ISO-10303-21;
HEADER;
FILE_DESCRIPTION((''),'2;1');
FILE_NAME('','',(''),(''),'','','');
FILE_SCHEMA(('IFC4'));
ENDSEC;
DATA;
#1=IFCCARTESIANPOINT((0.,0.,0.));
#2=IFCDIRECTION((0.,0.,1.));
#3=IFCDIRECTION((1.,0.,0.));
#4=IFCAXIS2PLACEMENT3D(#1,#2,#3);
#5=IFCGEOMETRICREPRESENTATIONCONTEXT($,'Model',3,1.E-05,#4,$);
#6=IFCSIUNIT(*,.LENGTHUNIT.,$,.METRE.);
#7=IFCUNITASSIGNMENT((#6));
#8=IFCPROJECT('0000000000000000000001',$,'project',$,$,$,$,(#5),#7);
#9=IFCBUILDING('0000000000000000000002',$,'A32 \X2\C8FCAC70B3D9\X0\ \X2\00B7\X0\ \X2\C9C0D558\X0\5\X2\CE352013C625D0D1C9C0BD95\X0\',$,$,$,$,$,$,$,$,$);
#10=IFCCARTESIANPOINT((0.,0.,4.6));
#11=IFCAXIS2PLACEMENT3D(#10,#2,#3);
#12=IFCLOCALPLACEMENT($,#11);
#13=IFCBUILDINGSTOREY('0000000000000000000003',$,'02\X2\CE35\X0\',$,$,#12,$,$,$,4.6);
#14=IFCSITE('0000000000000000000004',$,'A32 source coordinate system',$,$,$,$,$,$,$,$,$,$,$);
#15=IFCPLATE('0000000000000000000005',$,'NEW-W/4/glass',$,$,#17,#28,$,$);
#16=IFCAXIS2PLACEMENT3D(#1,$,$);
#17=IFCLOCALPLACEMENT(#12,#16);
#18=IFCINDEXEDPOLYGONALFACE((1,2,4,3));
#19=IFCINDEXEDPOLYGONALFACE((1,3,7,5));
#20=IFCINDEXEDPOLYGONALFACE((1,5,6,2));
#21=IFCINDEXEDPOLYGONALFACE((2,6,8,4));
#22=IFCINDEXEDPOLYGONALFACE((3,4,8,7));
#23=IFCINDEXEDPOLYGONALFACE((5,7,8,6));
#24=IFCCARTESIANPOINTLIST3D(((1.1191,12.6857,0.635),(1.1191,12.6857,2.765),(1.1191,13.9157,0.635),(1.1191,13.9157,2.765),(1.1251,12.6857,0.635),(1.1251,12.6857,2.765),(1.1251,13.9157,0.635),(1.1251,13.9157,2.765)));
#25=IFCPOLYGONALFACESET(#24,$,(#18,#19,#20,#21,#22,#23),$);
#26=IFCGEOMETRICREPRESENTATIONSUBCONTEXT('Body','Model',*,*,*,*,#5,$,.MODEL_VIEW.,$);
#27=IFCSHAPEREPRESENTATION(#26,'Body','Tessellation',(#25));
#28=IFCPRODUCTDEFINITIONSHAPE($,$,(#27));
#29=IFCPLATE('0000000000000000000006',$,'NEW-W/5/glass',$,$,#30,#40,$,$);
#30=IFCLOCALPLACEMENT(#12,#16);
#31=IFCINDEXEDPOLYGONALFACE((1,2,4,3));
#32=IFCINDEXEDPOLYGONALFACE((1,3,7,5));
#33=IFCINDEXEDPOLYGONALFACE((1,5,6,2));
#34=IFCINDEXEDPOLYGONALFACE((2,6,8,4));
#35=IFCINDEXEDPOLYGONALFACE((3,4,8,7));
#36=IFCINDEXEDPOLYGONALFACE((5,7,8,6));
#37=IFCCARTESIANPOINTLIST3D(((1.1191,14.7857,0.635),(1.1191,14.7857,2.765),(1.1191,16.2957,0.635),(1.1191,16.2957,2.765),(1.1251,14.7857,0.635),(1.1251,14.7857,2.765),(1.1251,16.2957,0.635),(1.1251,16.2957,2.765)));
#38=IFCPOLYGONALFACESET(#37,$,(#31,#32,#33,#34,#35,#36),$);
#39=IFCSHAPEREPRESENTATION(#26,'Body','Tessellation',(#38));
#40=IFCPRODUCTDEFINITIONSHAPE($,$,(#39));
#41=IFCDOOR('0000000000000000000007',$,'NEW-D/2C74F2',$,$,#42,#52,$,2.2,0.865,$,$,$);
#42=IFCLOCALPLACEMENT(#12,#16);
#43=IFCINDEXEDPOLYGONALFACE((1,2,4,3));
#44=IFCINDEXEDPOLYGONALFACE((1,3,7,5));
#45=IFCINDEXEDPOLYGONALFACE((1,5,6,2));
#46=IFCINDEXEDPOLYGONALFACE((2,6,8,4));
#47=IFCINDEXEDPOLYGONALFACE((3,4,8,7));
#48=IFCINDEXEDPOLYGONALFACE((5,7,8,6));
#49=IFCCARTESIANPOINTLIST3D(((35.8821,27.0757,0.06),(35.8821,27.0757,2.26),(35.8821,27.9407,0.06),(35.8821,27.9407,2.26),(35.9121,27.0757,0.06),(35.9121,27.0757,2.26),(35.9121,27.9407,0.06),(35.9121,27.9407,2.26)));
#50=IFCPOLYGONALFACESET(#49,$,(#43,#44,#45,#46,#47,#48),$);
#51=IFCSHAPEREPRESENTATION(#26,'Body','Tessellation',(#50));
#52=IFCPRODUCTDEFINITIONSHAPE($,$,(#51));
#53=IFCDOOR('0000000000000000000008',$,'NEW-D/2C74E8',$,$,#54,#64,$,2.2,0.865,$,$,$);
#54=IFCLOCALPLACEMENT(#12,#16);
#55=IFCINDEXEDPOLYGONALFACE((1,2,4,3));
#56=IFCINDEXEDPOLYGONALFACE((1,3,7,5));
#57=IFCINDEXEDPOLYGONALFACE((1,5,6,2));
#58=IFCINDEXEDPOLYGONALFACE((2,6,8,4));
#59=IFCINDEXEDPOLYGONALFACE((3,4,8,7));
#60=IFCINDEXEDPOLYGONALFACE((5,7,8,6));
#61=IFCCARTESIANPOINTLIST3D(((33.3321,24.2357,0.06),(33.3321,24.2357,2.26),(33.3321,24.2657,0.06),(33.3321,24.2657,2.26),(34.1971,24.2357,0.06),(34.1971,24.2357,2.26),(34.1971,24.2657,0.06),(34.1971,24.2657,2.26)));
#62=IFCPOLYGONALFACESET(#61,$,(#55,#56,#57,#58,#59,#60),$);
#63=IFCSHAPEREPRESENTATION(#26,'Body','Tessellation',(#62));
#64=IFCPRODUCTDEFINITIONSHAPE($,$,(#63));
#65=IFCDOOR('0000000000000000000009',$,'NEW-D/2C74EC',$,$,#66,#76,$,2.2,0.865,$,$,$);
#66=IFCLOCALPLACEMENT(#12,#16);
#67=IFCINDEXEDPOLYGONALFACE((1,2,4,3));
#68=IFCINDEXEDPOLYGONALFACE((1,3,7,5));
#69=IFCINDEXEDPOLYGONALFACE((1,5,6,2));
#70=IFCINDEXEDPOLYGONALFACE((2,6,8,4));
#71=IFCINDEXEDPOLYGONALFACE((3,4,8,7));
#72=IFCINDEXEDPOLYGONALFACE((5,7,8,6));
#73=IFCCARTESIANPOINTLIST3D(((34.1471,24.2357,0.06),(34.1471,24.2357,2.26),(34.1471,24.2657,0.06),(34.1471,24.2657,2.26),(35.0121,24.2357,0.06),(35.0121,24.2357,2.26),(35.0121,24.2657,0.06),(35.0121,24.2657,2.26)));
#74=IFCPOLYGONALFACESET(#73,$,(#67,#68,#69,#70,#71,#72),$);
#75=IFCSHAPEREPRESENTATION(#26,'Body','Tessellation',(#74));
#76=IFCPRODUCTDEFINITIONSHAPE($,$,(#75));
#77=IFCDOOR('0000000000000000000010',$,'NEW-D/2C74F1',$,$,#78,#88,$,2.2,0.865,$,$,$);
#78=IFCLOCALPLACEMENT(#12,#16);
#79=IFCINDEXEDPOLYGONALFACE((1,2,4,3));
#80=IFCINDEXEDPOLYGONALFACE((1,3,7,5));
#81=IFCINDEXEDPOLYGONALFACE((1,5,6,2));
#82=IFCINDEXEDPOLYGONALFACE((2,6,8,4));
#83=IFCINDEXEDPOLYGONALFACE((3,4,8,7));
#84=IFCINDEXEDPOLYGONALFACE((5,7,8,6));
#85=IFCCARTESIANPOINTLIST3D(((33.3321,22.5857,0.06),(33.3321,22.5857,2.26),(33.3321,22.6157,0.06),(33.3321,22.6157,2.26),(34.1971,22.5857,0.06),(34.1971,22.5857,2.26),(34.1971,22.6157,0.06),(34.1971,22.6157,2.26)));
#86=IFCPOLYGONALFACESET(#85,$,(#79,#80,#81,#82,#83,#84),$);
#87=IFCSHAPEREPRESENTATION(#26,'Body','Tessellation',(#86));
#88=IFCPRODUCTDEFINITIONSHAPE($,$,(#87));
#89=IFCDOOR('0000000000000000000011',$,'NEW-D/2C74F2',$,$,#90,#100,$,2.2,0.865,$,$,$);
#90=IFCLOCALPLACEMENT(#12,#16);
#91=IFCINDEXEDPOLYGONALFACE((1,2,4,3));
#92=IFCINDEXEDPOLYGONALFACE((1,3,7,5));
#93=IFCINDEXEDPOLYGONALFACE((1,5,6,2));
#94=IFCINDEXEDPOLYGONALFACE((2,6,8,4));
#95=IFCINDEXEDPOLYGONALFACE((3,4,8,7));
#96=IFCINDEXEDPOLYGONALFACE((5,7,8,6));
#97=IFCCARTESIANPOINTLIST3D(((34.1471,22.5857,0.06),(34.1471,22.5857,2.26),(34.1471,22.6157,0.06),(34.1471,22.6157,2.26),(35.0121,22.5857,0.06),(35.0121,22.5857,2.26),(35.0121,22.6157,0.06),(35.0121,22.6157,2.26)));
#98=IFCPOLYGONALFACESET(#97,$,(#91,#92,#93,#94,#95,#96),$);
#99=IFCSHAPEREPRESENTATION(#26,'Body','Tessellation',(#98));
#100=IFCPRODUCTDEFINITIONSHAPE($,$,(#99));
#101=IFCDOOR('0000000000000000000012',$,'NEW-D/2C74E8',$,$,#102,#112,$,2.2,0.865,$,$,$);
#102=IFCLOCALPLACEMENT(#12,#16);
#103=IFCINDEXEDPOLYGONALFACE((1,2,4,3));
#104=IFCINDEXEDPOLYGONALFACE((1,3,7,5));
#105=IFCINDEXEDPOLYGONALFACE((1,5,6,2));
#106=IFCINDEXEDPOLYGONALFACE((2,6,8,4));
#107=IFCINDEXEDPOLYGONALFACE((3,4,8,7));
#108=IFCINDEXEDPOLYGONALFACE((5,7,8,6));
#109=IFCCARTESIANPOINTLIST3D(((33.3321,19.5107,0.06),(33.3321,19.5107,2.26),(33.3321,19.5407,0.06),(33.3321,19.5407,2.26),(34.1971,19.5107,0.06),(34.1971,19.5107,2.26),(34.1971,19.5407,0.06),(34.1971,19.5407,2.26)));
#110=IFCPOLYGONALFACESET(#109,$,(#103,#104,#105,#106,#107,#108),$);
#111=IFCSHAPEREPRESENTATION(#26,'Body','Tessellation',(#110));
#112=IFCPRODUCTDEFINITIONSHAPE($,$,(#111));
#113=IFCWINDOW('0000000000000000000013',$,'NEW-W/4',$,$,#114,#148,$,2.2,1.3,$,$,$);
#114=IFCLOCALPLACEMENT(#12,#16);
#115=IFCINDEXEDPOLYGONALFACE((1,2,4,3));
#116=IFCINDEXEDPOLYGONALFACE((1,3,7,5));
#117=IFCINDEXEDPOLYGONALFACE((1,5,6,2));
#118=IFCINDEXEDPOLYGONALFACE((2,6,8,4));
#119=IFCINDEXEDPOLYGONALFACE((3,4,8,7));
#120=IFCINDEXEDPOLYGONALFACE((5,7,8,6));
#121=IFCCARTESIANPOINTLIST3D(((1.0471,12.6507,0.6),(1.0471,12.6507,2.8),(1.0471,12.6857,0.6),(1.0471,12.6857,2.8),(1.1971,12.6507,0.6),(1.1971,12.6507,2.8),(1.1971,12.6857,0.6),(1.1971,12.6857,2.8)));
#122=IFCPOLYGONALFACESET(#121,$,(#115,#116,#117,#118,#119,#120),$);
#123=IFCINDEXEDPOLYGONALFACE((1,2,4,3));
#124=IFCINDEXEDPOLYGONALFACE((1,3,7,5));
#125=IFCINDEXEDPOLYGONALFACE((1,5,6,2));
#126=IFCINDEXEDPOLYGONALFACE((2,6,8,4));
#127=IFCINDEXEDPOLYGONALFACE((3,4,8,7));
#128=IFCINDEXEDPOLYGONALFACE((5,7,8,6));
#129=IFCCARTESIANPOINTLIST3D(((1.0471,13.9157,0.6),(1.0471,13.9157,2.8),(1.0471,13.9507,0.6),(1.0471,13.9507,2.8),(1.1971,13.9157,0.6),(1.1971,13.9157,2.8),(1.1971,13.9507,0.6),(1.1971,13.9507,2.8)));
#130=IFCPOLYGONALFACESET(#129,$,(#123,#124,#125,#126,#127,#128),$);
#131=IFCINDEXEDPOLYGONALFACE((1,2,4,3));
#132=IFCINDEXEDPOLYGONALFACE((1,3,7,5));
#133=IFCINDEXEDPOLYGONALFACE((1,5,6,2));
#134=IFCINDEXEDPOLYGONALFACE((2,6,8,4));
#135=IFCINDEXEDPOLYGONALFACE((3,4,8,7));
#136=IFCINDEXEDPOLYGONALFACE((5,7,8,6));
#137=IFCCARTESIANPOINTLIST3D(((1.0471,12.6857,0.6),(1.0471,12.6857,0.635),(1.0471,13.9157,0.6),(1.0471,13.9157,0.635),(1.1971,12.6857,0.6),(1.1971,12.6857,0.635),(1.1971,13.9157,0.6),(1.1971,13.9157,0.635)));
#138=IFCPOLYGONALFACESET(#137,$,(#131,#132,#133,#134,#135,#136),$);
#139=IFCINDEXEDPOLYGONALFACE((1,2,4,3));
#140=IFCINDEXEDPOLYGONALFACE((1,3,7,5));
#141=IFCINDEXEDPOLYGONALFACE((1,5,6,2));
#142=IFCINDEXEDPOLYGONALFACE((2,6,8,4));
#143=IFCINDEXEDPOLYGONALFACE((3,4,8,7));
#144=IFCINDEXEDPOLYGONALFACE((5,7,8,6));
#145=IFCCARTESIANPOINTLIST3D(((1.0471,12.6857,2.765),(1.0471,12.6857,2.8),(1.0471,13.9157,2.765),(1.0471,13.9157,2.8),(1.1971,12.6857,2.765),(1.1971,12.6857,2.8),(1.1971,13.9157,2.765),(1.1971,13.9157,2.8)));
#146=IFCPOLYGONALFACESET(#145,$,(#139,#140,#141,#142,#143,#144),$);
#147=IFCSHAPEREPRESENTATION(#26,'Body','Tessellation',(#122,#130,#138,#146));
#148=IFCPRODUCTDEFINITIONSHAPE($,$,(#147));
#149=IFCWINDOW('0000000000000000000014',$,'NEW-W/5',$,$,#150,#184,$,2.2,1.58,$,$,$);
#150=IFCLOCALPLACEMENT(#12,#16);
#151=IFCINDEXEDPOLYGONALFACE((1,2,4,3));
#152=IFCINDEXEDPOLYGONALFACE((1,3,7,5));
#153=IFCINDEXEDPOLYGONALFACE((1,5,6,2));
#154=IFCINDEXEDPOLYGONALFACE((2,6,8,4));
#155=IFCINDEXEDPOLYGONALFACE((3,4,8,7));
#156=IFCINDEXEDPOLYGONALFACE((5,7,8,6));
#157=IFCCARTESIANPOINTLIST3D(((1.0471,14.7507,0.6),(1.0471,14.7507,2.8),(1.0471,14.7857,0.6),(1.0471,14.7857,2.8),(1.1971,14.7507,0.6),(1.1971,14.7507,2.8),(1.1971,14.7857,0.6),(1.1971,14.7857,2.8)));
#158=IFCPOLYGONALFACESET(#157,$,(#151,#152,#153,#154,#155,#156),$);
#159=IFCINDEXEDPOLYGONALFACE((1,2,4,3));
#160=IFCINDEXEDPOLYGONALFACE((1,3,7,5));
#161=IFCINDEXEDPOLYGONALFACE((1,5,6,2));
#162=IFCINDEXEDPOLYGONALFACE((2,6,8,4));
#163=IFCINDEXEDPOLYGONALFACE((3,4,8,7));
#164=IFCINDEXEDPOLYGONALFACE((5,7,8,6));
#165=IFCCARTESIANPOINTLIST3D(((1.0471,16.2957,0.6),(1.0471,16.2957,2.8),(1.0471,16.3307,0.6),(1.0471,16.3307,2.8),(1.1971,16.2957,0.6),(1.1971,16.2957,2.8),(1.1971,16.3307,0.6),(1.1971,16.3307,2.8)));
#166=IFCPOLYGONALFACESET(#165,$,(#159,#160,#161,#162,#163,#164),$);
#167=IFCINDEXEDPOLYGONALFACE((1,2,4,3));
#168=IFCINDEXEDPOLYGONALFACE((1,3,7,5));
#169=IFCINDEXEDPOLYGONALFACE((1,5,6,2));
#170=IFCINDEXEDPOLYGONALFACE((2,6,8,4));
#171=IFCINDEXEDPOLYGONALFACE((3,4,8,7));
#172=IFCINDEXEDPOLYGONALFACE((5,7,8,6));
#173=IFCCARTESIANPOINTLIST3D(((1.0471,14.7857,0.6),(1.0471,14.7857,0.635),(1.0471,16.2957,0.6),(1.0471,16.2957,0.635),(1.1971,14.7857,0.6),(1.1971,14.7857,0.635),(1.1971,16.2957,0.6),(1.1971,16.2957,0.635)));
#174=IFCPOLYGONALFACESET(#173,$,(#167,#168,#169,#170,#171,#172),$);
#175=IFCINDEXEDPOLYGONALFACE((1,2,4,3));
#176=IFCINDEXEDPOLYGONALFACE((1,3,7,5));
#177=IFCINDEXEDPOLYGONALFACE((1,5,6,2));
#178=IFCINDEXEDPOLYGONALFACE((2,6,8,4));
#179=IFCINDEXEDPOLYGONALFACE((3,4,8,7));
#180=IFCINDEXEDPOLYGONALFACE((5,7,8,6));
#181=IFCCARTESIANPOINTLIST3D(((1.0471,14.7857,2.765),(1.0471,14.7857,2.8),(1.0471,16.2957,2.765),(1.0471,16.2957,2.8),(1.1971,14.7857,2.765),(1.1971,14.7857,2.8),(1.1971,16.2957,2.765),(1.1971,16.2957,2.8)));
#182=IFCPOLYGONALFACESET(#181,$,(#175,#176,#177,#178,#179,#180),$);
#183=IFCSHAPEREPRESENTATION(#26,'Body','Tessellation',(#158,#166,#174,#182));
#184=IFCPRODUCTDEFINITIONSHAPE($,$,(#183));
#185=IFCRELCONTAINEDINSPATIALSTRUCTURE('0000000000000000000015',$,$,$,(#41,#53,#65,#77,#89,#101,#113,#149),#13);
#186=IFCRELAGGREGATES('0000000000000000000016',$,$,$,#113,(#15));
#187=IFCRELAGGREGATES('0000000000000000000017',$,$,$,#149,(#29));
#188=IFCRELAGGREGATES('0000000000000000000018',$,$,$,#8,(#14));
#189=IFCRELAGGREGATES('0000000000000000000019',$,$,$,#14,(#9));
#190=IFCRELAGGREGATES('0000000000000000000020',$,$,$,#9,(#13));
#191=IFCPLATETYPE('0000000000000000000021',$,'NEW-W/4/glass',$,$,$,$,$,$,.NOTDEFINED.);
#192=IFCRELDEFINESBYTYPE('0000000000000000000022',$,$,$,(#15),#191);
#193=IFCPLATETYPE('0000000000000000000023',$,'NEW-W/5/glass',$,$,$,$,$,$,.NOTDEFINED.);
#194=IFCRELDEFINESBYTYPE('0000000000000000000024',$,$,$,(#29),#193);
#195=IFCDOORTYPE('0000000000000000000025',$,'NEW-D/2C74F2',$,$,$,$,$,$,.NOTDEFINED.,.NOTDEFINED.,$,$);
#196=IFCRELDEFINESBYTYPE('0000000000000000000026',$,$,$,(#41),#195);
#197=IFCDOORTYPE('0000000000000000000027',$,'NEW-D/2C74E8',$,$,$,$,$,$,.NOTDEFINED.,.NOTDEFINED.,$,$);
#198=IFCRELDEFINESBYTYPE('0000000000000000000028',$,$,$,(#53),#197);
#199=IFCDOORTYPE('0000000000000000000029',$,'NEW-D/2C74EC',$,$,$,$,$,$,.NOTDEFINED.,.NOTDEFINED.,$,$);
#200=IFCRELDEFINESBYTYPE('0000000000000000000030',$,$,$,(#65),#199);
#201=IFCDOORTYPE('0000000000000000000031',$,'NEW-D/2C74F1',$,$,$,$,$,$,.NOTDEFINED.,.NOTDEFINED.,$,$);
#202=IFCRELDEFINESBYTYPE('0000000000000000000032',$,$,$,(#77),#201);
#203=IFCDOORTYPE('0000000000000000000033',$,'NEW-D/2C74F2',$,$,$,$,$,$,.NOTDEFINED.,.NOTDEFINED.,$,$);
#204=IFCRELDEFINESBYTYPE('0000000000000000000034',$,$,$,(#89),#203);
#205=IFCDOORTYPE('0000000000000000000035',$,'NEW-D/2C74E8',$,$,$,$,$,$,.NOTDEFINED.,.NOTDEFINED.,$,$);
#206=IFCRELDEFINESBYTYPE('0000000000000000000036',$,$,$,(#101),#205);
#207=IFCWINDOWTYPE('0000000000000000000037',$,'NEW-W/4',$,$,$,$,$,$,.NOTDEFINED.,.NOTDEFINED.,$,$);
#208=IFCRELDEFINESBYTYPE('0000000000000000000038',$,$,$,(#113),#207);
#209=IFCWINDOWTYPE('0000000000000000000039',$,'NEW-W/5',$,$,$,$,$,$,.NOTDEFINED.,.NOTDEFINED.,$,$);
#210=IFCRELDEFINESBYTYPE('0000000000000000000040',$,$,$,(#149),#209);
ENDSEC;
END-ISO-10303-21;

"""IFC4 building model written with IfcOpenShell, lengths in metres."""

from ifc_helpers import new_model, si_unit, frame, origin, origin_with_axes, place, context, subcontext, project, spatial, polyline, outline, extrude, source, transform, mapped, type_object, type_shapes, element, aggregate, save


model = new_model("IFC4")

# Units and contexts
model_context = context("Model", 3, precision=1e-05, world=origin_with_axes())
body_context = subcontext(model_context, "Body", "Model", "MODEL_VIEW")
ifc_project = project(units=[si_unit("LENGTHUNIT", "METRE")], contexts=[model_context])

# Plates
storey_placement = place(None, frame((0.0, 0.0, 4.6), z_axis=(0.0, 0.0, 1.0), x_axis=(1.0, 0.0, 0.0)))
plate_type_1 = type_object("IfcPlateType", Name="NEW-W/4/glass", PredefinedType="NOTDEFINED")
shared_shape_1 = source(origin(), body_context, "Body", "SweptSolid", [
    extrude(outline(polyline([(1.1251, 12.6857), (1.1191, 12.6857), (1.1191, 13.9157), (1.1251, 13.9157), (1.1251, 12.6857)])), frame((0.0, 0.0, 0.635)), (0.0, 0.0, 1.0), 2.13),
])
type_shapes(plate_type_1, [shared_shape_1])
window_1_placement = place(storey_placement, origin_with_axes())
plate_1_placement = place(window_1_placement, origin_with_axes())
plate_1 = element("IfcPlate", 1, at=plate_1_placement, type_object=plate_type_1, Name="NEW-W/4/glass", context=body_context, shape_type="MappedRepresentation", body=[
    mapped(shared_shape_1, transform((0.0, 0.0, 0.0), scale=1.0)),
])
plate_type_2 = type_object("IfcPlateType", Name="NEW-W/5/glass", PredefinedType="NOTDEFINED")
shared_shape_2 = source(origin(), body_context, "Body", "SweptSolid", [
    extrude(outline(polyline([(1.1251, 14.7857), (1.1191, 14.7857), (1.1191, 16.2957), (1.1251, 16.2957), (1.1251, 14.7857)])), frame((0.0, 0.0, 0.635)), (0.0, 0.0, 1.0), 2.13),
])
type_shapes(plate_type_2, [shared_shape_2])
window_2_placement = place(storey_placement, origin_with_axes())
plate_2_placement = place(window_2_placement, origin_with_axes())
plate_2 = element("IfcPlate", 2, at=plate_2_placement, type_object=plate_type_2, Name="NEW-W/5/glass", context=body_context, shape_type="MappedRepresentation", body=[
    mapped(shared_shape_2, transform((0.0, 0.0, 0.0), scale=1.0)),
])

# Site, building, storey
site = spatial("IfcSite", under=ifc_project, Name="A32 source coordinate system")
building = spatial("IfcBuilding", under=site, Name="A32 주거동 · 지하5층–옥탑지붕")
storey = spatial("IfcBuildingStorey", under=building, at=storey_placement, Name="02층", Elevation=4.6)

# Doors
door_type_1 = type_object("IfcDoorType", Name="NEW-D/2C74F2", OperationType="NOTDEFINED", PredefinedType="NOTDEFINED")
shared_shape_3 = source(origin(), body_context, "Body", "SweptSolid", [
    extrude(outline(polyline([(35.8821, 27.0757), (35.8821, 27.9407), (35.9121, 27.9407), (35.9121, 27.0757), (35.8821, 27.0757)])), frame((0.0, 0.0, 0.06)), (0.0, 0.0, 1.0), 2.2),
])
type_shapes(door_type_1, [shared_shape_3])
door_1_placement = place(storey_placement, origin_with_axes())
element("IfcDoor", 3, at=door_1_placement, inside=storey, type_object=door_type_1, Name="NEW-D/2C74F2", OverallHeight=2.2, OverallWidth=0.865, context=body_context, shape_type="MappedRepresentation", body=[
    mapped(shared_shape_3, transform((0.0, 0.0, 0.0), scale=1.0)),
])
door_type_2 = type_object("IfcDoorType", Name="NEW-D/2C74E8", OperationType="NOTDEFINED", PredefinedType="NOTDEFINED")
shared_shape_4 = source(origin(), body_context, "Body", "SweptSolid", [
    extrude(outline(polyline([(34.1971, 24.2357), (33.3321, 24.2357), (33.3321, 24.2657), (34.1971, 24.2657), (34.1971, 24.2357)])), frame((0.0, 0.0, 0.06)), (0.0, 0.0, 1.0), 2.2),
])
type_shapes(door_type_2, [shared_shape_4])
door_2_placement = place(storey_placement, origin_with_axes())
element("IfcDoor", 4, at=door_2_placement, inside=storey, type_object=door_type_2, Name="NEW-D/2C74E8", OverallHeight=2.2, OverallWidth=0.865, context=body_context, shape_type="MappedRepresentation", body=[
    mapped(shared_shape_4, transform((0.0, 0.0, 0.0), scale=1.0)),
])
door_type_3 = type_object("IfcDoorType", Name="NEW-D/2C74EC", OperationType="NOTDEFINED", PredefinedType="NOTDEFINED")
shared_shape_5 = source(origin(), body_context, "Body", "SweptSolid", [
    extrude(outline(polyline([(35.0121, 24.2657), (35.0121, 24.2357), (34.1471, 24.2357), (34.1471, 24.2657), (35.0121, 24.2657)])), frame((0.0, 0.0, 0.06)), (0.0, 0.0, 1.0), 2.2),
])
type_shapes(door_type_3, [shared_shape_5])
door_3_placement = place(storey_placement, origin_with_axes())
element("IfcDoor", 5, at=door_3_placement, inside=storey, type_object=door_type_3, Name="NEW-D/2C74EC", OverallHeight=2.2, OverallWidth=0.865, context=body_context, shape_type="MappedRepresentation", body=[
    mapped(shared_shape_5, transform((0.0, 0.0, 0.0), scale=1.0)),
])
door_type_4 = type_object("IfcDoorType", Name="NEW-D/2C74F1", OperationType="NOTDEFINED", PredefinedType="NOTDEFINED")
shared_shape_6 = source(origin(), body_context, "Body", "SweptSolid", [
    extrude(outline(polyline([(33.3321, 22.5857), (33.3321, 22.6157), (34.1971, 22.6157), (34.1971, 22.5857), (33.3321, 22.5857)])), frame((0.0, 0.0, 0.06)), (0.0, 0.0, 1.0), 2.2),
])
type_shapes(door_type_4, [shared_shape_6])
door_4_placement = place(storey_placement, origin_with_axes())
element("IfcDoor", 6, at=door_4_placement, inside=storey, type_object=door_type_4, Name="NEW-D/2C74F1", OverallHeight=2.2, OverallWidth=0.865, context=body_context, shape_type="MappedRepresentation", body=[
    mapped(shared_shape_6, transform((0.0, 0.0, 0.0), scale=1.0)),
])
door_type_5 = type_object("IfcDoorType", Name="NEW-D/2C74F2", OperationType="NOTDEFINED", PredefinedType="NOTDEFINED")
shared_shape_7 = source(origin(), body_context, "Body", "SweptSolid", [
    extrude(outline(polyline([(34.1471, 22.6157), (35.0121, 22.6157), (35.0121, 22.5857), (34.1471, 22.5857), (34.1471, 22.6157)])), frame((0.0, 0.0, 0.06)), (0.0, 0.0, 1.0), 2.2),
])
type_shapes(door_type_5, [shared_shape_7])
door_5_placement = place(storey_placement, origin_with_axes())
element("IfcDoor", 7, at=door_5_placement, inside=storey, type_object=door_type_5, Name="NEW-D/2C74F2", OverallHeight=2.2, OverallWidth=0.865, context=body_context, shape_type="MappedRepresentation", body=[
    mapped(shared_shape_7, transform((0.0, 0.0, 0.0), scale=1.0)),
])
door_type_6 = type_object("IfcDoorType", Name="NEW-D/2C74E8", OperationType="NOTDEFINED", PredefinedType="NOTDEFINED")
shared_shape_8 = source(origin(), body_context, "Body", "SweptSolid", [
    extrude(outline(polyline([(34.1971, 19.5107), (33.3321, 19.5107), (33.3321, 19.5407), (34.1971, 19.5407), (34.1971, 19.5107)])), frame((0.0, 0.0, 0.06)), (0.0, 0.0, 1.0), 2.2),
])
type_shapes(door_type_6, [shared_shape_8])
door_6_placement = place(storey_placement, origin_with_axes())
element("IfcDoor", 8, at=door_6_placement, inside=storey, type_object=door_type_6, Name="NEW-D/2C74E8", OverallHeight=2.2, OverallWidth=0.865, context=body_context, shape_type="MappedRepresentation", body=[
    mapped(shared_shape_8, transform((0.0, 0.0, 0.0), scale=1.0)),
])

# Windows
window_type_1 = type_object("IfcWindowType", Name="NEW-W/4", PartitioningType="NOTDEFINED", PredefinedType="NOTDEFINED")
shared_shape_9 = source(origin(), body_context, "Body", "SweptSolid", [
    extrude(outline(polyline([(1.0471, 12.6507), (1.0471, 12.6857), (1.1971, 12.6857), (1.1971, 12.6507), (1.0471, 12.6507)])), frame((0.0, 0.0, 0.6)), (0.0, 0.0, 1.0), 2.2),
    extrude(outline(polyline([(1.0471, 13.9157), (1.0471, 13.9507), (1.1971, 13.9507), (1.1971, 13.9157), (1.0471, 13.9157)])), frame((0.0, 0.0, 0.6)), (0.0, 0.0, 1.0), 2.2),
    extrude(outline(polyline([(1.1971, 12.6857), (1.1971, 13.9157), (1.0471, 13.9157), (1.0471, 12.6857), (1.1971, 12.6857)])), frame((0.0, 0.0, 0.6)), (0.0, 0.0, 1.0), 0.035),
    extrude(outline(polyline([(1.1971, 12.6857), (1.1971, 13.9157), (1.0471, 13.9157), (1.0471, 12.6857), (1.1971, 12.6857)])), frame((0.0, 0.0, 2.765)), (0.0, 0.0, 1.0), 0.035),
])
type_shapes(window_type_1, [shared_shape_9])
window_1 = element("IfcWindow", 9, at=window_1_placement, inside=storey, type_object=window_type_1, Name="NEW-W/4", OverallHeight=2.2, OverallWidth=1.3, context=body_context, shape_type="MappedRepresentation", body=[
    mapped(shared_shape_9, transform((0.0, 0.0, 0.0), scale=1.0)),
])
aggregate(window_1, [plate_1])
window_type_2 = type_object("IfcWindowType", Name="NEW-W/5", PartitioningType="NOTDEFINED", PredefinedType="NOTDEFINED")
shared_shape_10 = source(origin(), body_context, "Body", "SweptSolid", [
    extrude(outline(polyline([(1.0471, 14.7507), (1.0471, 14.7857), (1.1971, 14.7857), (1.1971, 14.7507), (1.0471, 14.7507)])), frame((0.0, 0.0, 0.6)), (0.0, 0.0, 1.0), 2.2),
    extrude(outline(polyline([(1.0471, 16.2957), (1.0471, 16.3307), (1.1971, 16.3307), (1.1971, 16.2957), (1.0471, 16.2957)])), frame((0.0, 0.0, 0.6)), (0.0, 0.0, 1.0), 2.2),
    extrude(outline(polyline([(1.1971, 14.7857), (1.1971, 16.2957), (1.0471, 16.2957), (1.0471, 14.7857), (1.1971, 14.7857)])), frame((0.0, 0.0, 0.6)), (0.0, 0.0, 1.0), 0.035),
    extrude(outline(polyline([(1.1971, 14.7857), (1.1971, 16.2957), (1.0471, 16.2957), (1.0471, 14.7857), (1.1971, 14.7857)])), frame((0.0, 0.0, 2.765)), (0.0, 0.0, 1.0), 0.035),
])
type_shapes(window_type_2, [shared_shape_10])
window_2 = element("IfcWindow", 10, at=window_2_placement, inside=storey, type_object=window_type_2, Name="NEW-W/5", OverallHeight=2.2, OverallWidth=1.58, context=body_context, shape_type="MappedRepresentation", body=[
    mapped(shared_shape_10, transform((0.0, 0.0, 0.0), scale=1.0)),
])
aggregate(window_2, [plate_2])

save(model, "model.ifc")
